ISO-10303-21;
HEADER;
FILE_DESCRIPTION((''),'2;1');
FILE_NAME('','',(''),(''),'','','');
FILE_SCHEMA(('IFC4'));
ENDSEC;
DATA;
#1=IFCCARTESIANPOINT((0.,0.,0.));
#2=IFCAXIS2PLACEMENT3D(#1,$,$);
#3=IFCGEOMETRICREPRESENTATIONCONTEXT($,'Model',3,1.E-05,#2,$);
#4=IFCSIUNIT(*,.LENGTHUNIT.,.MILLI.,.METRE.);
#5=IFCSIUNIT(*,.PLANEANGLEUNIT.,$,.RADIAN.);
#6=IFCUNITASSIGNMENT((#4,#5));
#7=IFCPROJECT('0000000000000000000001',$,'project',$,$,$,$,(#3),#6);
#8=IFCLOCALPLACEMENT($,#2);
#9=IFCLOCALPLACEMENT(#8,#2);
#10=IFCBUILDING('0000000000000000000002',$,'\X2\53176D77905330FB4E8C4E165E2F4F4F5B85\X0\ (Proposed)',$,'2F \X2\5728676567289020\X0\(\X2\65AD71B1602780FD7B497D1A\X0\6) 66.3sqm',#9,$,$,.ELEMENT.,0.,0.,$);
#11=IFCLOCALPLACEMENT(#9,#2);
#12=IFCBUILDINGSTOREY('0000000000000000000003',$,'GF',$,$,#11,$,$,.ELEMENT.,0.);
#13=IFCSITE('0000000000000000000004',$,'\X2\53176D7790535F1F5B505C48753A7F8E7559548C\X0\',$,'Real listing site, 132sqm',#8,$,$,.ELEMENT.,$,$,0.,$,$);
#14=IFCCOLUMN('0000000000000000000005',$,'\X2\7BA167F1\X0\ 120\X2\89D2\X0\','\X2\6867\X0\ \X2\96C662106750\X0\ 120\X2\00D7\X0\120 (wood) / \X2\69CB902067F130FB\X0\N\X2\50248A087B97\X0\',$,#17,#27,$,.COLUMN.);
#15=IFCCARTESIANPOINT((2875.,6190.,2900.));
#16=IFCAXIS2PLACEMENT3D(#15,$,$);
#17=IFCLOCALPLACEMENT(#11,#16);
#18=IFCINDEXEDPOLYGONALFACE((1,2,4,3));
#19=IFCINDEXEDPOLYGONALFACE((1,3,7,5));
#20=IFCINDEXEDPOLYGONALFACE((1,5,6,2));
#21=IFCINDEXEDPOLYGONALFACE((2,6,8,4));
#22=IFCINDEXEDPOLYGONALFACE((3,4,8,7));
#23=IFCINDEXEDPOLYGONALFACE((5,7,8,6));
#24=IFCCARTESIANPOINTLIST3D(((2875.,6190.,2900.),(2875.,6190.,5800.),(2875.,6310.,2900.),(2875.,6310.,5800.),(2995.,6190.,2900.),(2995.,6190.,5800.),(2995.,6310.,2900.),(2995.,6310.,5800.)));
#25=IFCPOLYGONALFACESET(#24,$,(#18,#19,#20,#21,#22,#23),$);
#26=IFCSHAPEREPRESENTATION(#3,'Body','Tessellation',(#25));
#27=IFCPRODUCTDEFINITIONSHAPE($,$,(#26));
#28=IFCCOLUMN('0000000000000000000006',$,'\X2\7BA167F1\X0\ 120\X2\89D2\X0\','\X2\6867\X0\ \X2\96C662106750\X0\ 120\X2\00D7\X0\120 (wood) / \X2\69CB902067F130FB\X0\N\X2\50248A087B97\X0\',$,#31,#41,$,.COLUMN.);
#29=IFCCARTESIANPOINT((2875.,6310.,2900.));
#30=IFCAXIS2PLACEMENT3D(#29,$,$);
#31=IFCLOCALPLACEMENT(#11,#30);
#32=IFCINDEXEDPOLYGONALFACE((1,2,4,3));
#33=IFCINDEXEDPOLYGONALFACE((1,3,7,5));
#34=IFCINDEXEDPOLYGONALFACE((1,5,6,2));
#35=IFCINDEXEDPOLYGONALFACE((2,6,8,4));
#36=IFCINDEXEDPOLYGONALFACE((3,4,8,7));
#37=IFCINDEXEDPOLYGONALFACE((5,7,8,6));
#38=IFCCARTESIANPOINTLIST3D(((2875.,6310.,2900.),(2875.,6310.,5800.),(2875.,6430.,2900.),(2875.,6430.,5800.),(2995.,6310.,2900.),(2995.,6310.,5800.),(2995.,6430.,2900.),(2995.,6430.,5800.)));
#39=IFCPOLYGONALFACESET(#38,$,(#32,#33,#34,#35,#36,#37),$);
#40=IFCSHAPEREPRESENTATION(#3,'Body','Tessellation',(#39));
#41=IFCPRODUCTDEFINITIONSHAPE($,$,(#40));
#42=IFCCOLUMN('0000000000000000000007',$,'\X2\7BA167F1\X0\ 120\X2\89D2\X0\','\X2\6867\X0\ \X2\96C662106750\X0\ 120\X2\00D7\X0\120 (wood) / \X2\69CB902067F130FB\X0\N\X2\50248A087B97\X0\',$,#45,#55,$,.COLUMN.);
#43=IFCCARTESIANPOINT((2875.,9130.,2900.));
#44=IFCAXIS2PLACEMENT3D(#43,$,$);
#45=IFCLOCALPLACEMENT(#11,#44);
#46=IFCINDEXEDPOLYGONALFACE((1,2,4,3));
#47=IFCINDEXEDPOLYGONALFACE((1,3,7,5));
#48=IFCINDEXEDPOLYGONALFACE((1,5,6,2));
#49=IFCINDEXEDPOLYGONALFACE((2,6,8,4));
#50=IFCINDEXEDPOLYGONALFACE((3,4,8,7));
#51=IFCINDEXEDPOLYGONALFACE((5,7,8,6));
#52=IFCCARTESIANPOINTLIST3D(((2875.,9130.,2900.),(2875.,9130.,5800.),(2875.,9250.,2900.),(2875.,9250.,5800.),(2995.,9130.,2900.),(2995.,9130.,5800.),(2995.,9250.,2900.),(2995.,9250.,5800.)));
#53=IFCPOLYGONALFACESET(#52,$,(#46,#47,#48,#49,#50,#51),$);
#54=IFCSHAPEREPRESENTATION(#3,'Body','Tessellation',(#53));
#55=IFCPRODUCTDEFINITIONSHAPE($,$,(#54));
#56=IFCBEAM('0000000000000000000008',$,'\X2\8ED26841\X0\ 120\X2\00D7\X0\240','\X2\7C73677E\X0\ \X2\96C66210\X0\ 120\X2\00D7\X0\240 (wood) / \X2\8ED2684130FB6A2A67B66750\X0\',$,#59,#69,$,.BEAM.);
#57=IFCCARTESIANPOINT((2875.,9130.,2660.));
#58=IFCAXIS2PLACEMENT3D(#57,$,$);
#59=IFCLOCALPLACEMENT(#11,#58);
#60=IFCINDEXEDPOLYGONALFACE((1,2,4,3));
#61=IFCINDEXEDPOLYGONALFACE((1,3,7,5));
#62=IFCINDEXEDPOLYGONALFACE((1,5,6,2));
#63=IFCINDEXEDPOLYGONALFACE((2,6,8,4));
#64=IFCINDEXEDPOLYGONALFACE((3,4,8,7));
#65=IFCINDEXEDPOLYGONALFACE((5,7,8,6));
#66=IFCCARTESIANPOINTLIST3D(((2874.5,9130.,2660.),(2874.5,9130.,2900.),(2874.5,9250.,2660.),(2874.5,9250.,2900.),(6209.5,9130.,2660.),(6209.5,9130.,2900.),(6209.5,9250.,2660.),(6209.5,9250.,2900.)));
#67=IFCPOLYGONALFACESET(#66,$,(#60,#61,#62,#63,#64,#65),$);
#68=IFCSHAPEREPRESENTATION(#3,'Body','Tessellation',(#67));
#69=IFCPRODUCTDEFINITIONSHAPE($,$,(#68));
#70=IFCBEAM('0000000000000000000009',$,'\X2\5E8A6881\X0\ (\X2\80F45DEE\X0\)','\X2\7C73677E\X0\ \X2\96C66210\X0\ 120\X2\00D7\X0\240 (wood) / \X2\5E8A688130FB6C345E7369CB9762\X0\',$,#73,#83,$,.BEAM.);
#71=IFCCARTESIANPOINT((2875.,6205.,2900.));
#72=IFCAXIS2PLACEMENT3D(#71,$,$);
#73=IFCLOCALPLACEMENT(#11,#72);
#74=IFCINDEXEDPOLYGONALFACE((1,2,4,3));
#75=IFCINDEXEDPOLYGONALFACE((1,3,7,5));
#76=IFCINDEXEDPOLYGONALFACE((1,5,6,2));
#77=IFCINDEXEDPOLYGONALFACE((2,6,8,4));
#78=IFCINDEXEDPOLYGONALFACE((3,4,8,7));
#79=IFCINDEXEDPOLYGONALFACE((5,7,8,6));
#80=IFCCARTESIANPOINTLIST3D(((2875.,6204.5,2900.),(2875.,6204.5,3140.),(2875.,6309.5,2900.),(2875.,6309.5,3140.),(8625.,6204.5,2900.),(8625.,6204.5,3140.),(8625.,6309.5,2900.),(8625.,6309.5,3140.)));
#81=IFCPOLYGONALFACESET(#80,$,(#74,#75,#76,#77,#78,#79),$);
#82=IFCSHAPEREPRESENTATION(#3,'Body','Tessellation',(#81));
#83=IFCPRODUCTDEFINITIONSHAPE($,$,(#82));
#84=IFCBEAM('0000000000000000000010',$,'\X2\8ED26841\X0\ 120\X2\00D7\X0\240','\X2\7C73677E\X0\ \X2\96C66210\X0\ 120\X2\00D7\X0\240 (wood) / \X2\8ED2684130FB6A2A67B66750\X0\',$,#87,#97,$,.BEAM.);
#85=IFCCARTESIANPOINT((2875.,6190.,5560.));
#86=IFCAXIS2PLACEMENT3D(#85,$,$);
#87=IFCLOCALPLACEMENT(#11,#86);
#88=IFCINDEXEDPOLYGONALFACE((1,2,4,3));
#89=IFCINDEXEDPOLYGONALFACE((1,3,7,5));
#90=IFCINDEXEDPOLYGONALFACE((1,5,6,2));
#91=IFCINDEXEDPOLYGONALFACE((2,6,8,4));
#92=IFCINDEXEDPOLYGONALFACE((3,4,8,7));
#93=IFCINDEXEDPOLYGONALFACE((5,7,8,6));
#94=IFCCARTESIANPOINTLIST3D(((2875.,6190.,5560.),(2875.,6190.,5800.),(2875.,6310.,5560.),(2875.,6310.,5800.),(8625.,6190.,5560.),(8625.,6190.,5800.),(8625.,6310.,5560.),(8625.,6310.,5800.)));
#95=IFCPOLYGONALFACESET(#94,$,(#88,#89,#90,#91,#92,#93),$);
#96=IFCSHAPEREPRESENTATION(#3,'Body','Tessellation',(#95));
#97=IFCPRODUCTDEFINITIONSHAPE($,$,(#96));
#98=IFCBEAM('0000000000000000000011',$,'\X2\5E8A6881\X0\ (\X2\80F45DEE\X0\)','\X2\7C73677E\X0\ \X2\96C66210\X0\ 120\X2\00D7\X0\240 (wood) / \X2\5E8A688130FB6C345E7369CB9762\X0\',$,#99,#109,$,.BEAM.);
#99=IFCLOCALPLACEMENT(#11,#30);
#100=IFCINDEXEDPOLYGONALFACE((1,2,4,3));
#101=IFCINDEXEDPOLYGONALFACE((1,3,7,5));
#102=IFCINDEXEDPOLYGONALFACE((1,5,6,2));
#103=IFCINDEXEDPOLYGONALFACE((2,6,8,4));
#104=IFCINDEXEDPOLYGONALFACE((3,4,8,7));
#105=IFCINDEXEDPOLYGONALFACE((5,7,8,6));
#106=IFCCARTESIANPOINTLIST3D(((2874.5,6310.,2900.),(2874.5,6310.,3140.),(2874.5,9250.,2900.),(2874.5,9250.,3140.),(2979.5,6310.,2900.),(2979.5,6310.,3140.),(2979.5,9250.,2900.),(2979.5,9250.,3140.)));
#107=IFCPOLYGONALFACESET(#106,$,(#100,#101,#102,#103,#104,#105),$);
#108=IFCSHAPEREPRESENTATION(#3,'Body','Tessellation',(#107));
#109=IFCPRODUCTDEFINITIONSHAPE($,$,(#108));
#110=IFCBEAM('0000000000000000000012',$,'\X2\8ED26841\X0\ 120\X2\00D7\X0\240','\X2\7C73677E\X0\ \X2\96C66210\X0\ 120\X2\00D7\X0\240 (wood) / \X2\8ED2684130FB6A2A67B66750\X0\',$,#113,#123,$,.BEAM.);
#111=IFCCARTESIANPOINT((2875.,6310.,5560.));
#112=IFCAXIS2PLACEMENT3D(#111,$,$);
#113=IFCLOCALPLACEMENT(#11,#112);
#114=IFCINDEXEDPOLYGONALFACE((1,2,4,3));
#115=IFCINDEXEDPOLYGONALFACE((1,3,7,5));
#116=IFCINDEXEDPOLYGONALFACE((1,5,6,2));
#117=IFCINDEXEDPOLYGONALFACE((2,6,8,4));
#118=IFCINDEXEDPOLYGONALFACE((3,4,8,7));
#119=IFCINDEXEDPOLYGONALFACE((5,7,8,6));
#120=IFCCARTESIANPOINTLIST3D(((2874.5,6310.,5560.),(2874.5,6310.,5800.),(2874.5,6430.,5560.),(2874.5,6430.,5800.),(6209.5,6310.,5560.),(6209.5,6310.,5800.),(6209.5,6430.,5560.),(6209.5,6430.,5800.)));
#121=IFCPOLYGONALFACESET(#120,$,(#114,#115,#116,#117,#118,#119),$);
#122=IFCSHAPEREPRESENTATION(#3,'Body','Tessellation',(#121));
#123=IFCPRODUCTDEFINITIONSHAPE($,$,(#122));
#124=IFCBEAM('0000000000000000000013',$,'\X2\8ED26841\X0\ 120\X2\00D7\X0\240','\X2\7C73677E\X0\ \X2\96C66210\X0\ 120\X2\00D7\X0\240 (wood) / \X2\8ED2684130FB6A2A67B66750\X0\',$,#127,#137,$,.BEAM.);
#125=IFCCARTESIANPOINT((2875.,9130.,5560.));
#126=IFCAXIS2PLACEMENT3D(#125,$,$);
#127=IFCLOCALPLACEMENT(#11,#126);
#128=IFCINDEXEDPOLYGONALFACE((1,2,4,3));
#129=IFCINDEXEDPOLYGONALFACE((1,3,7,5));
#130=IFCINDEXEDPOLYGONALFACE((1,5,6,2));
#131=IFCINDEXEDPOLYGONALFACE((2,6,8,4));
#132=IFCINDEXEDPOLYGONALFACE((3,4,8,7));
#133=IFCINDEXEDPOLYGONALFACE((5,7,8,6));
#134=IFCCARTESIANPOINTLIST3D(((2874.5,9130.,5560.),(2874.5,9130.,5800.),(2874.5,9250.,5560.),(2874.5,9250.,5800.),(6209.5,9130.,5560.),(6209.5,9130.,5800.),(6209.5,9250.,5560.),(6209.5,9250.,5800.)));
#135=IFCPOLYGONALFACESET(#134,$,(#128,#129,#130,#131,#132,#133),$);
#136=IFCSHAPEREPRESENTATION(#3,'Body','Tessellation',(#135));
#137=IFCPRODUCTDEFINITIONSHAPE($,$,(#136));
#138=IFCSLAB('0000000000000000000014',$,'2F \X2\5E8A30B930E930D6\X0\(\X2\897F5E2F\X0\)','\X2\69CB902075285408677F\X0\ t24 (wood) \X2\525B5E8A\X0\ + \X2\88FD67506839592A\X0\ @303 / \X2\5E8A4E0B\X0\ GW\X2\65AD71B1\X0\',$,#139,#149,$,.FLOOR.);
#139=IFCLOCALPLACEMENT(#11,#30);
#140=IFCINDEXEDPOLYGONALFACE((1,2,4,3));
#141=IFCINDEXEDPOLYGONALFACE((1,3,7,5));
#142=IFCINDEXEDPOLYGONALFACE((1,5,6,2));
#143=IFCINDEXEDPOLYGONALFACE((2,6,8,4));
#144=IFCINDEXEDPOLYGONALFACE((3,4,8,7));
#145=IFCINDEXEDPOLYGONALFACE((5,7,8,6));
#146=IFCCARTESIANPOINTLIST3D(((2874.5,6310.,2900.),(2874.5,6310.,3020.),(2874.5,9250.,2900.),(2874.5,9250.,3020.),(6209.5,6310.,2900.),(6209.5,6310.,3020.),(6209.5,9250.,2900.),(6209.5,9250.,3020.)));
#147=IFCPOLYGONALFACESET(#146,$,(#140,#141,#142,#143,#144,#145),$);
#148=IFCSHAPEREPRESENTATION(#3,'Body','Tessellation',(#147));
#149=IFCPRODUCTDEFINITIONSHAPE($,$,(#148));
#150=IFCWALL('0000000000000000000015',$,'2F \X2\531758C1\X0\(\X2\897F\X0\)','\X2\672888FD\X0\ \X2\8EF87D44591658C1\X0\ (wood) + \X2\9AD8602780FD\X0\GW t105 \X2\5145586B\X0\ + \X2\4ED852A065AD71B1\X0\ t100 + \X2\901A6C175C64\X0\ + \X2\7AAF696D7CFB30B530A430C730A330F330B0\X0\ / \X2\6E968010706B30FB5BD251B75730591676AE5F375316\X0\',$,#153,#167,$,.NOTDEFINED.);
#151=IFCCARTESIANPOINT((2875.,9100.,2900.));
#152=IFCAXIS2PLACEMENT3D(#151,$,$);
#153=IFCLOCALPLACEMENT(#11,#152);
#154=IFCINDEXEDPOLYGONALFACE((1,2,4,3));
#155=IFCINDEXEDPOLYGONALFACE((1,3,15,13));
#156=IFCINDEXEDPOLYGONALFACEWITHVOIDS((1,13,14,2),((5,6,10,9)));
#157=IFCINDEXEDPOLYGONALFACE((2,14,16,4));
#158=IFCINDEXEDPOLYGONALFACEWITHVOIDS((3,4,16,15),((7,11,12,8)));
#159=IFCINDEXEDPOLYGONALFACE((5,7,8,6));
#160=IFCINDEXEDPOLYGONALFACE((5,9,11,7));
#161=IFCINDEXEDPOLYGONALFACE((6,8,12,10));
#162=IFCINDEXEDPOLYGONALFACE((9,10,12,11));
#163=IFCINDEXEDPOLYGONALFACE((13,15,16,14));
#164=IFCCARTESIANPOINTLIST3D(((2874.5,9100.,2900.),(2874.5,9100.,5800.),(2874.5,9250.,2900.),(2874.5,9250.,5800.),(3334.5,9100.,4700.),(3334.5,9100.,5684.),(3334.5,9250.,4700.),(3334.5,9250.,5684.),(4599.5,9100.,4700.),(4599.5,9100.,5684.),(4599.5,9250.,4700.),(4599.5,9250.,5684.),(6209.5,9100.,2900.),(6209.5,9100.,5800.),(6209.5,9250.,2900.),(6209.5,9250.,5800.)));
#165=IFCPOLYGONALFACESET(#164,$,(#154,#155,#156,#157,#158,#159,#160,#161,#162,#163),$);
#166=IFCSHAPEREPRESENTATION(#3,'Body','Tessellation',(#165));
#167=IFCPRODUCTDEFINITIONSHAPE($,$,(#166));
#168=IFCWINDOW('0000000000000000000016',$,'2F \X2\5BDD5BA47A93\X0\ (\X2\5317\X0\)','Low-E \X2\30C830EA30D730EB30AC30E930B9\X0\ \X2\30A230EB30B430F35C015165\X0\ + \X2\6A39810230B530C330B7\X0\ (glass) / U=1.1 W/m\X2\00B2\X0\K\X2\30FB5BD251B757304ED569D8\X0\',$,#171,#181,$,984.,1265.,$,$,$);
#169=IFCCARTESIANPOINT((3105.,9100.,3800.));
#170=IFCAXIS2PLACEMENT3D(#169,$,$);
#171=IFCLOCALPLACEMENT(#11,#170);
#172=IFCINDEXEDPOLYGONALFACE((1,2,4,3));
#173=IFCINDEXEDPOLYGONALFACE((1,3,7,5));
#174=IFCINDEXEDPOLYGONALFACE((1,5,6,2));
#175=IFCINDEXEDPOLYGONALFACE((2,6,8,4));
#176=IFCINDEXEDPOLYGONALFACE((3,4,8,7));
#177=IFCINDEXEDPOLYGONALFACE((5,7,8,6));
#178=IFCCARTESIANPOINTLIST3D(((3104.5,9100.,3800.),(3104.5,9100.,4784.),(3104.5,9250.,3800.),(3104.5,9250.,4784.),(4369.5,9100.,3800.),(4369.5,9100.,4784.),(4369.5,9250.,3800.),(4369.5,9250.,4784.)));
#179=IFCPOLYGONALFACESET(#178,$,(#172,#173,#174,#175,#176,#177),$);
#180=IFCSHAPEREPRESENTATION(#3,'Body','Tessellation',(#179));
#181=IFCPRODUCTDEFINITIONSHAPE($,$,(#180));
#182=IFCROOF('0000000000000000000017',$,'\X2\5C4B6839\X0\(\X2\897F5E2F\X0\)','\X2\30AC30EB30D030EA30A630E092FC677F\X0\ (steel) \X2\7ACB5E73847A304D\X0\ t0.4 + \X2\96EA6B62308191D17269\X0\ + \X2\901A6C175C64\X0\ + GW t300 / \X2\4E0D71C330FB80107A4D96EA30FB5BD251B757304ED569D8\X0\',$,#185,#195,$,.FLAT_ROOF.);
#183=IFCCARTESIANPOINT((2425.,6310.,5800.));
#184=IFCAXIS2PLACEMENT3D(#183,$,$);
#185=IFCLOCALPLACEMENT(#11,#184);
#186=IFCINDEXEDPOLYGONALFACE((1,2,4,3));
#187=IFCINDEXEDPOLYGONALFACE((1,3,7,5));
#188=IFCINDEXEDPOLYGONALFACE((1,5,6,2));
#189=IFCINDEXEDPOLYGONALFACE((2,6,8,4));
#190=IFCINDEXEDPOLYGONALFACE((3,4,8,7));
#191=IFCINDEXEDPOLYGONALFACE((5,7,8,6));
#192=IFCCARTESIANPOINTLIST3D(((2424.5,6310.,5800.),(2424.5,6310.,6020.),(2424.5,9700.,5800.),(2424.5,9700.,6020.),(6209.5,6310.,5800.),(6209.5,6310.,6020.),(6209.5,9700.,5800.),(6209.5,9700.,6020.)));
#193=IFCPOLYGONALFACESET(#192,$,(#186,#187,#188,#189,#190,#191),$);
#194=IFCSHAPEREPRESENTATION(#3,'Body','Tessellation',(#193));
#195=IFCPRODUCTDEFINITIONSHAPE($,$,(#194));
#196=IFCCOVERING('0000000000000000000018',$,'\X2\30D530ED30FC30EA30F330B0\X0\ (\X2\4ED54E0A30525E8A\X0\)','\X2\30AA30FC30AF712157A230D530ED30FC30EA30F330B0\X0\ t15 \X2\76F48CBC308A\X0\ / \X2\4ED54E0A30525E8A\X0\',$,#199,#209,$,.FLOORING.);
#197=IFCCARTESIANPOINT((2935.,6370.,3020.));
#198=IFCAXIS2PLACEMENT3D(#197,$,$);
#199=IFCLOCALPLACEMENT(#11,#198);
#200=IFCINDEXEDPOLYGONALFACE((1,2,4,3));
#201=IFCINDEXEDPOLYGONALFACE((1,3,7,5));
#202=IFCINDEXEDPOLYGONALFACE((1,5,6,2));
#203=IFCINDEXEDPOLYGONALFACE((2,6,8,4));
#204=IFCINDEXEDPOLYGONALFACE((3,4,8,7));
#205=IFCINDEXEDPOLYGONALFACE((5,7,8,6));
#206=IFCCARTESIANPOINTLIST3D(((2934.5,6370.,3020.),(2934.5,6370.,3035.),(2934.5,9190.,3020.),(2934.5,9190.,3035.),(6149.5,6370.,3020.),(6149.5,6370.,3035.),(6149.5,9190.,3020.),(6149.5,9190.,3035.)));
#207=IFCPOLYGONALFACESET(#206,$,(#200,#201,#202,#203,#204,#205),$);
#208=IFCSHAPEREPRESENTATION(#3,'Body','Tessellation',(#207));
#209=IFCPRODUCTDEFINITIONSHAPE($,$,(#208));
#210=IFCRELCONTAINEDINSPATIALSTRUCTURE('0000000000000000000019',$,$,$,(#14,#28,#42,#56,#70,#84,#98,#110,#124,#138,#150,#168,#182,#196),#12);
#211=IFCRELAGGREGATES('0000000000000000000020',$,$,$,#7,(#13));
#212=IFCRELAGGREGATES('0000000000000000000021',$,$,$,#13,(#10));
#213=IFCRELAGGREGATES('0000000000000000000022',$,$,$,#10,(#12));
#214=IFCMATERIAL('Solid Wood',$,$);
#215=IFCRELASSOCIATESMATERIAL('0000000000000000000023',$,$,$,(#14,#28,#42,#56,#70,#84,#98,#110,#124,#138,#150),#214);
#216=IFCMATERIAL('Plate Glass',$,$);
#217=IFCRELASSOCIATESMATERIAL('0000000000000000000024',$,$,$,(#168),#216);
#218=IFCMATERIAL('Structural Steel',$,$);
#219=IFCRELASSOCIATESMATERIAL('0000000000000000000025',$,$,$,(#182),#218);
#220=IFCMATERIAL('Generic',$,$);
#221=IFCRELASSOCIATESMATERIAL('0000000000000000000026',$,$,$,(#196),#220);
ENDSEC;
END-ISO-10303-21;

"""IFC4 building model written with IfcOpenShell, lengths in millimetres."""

from ifc_helpers import new_model, si_unit, frame, frame_2d, origin, place, context, project, spatial, rectangle, extrude, material, element, fill, save


model = new_model("IFC4")

# Units and contexts
model_context = context("Model", 3, precision=1e-05, world=origin())
ifc_project = project(units=[si_unit("LENGTHUNIT", "METRE", prefix="MILLI"), si_unit("PLANEANGLEUNIT", "RADIAN")], contexts=[model_context])

# Site, building, storey
site_placement = place(None, origin())
site = spatial("IfcSite", under=ifc_project, at=site_placement, Name="北海道弟子屈町美留和", ObjectType="Real listing site, 132sqm", CompositionType="ELEMENT", RefElevation=0.0)
building_placement = place(site_placement, origin())
building = spatial("IfcBuilding", under=site, at=building_placement, Name="北海道・二世帯住宅 (Proposed)", ObjectType="2F 在来木造(断熱性能等級6) 66.3sqm", CompositionType="ELEMENT", ElevationOfRefHeight=0.0, ElevationOfTerrain=0.0)
storey_placement = place(building_placement, origin())
storey = spatial("IfcBuildingStorey", under=building, at=storey_placement, Name="GF", CompositionType="ELEMENT", Elevation=0.0)

# Columns
ifc_material_1 = material(Name="Solid Wood")
column_1_placement = place(storey_placement, frame((2875.0, 6190.0, 2900.0)))
element("IfcColumn", 1, at=column_1_placement, inside=storey, material=ifc_material_1, Name="管柱 120角", Description="桧 集成材 120×120 (wood) / 構造柱・N値計算", PredefinedType="COLUMN", context=model_context, shape_type="SweptSolid", body=[
    extrude(rectangle(XDim=120.0, YDim=120.0, at=frame_2d((60.0, 60.0))), frame((2875.0, 6190.0, 2900.0)), (0.0, 0.0, 1.0), 2900.0),
])
column_2_placement = place(storey_placement, frame((2875.0, 6310.0, 2900.0)))
element("IfcColumn", 2, at=column_2_placement, inside=storey, material=ifc_material_1, Name="管柱 120角", Description="桧 集成材 120×120 (wood) / 構造柱・N値計算", PredefinedType="COLUMN", context=model_context, shape_type="SweptSolid", body=[
    extrude(rectangle(XDim=120.0, YDim=120.0, at=frame_2d((60.0, 60.0))), frame((2875.0, 6310.0, 2900.0)), (0.0, 0.0, 1.0), 2900.0),
])
column_3_placement = place(storey_placement, frame((2875.0, 9130.0, 2900.0)))
element("IfcColumn", 3, at=column_3_placement, inside=storey, material=ifc_material_1, Name="管柱 120角", Description="桧 集成材 120×120 (wood) / 構造柱・N値計算", PredefinedType="COLUMN", context=model_context, shape_type="SweptSolid", body=[
    extrude(rectangle(XDim=120.0, YDim=120.0, at=frame_2d((60.0, 60.0))), frame((2875.0, 9130.0, 2900.0)), (0.0, 0.0, 1.0), 2900.0),
])

# Beams
beam_1_placement = place(storey_placement, frame((2875.0, 9130.0, 2660.0)))
element("IfcBeam", 4, at=beam_1_placement, inside=storey, material=ifc_material_1, Name="軒桁 120×240", Description="米松 集成 120×240 (wood) / 軒桁・横架材", PredefinedType="BEAM", context=model_context, shape_type="SweptSolid", body=[
    extrude(rectangle(XDim=3335.0, YDim=120.0, at=frame_2d((1667.0, 60.0))), frame((2875.0, 9130.0, 2660.0)), (0.0, 0.0, 1.0), 240.0),
])
beam_2_placement = place(storey_placement, frame((2875.0, 6205.0, 2900.0)))
element("IfcBeam", 5, at=beam_2_placement, inside=storey, material=ifc_material_1, Name="床梁 (胴差)", Description="米松 集成 120×240 (wood) / 床梁・水平構面", PredefinedType="BEAM", context=model_context, shape_type="SweptSolid", body=[
    extrude(rectangle(XDim=5750.0, YDim=105.0, at=frame_2d((2875.0, 52.0))), frame((2875.0, 6205.0, 2900.0)), (0.0, 0.0, 1.0), 240.0),
])
beam_3_placement = place(storey_placement, frame((2875.0, 6190.0, 5560.0)))
element("IfcBeam", 6, at=beam_3_placement, inside=storey, material=ifc_material_1, Name="軒桁 120×240", Description="米松 集成 120×240 (wood) / 軒桁・横架材", PredefinedType="BEAM", context=model_context, shape_type="SweptSolid", body=[
    extrude(rectangle(XDim=5750.0, YDim=120.0, at=frame_2d((2875.0, 60.0))), frame((2875.0, 6190.0, 5560.0)), (0.0, 0.0, 1.0), 240.0),
])
beam_4_placement = place(storey_placement, frame((2875.0, 6310.0, 2900.0)))
element("IfcBeam", 7, at=beam_4_placement, inside=storey, material=ifc_material_1, Name="床梁 (胴差)", Description="米松 集成 120×240 (wood) / 床梁・水平構面", PredefinedType="BEAM", context=model_context, shape_type="SweptSolid", body=[
    extrude(rectangle(XDim=105.0, YDim=2940.0, at=frame_2d((52.0, 1470.0))), frame((2875.0, 6310.0, 2900.0)), (0.0, 0.0, 1.0), 240.0),
])
beam_5_placement = place(storey_placement, frame((2875.0, 6310.0, 5560.0)))
element("IfcBeam", 8, at=beam_5_placement, inside=storey, material=ifc_material_1, Name="軒桁 120×240", Description="米松 集成 120×240 (wood) / 軒桁・横架材", PredefinedType="BEAM", context=model_context, shape_type="SweptSolid", body=[
    extrude(rectangle(XDim=3335.0, YDim=120.0, at=frame_2d((1667.0, 60.0))), frame((2875.0, 6310.0, 5560.0)), (0.0, 0.0, 1.0), 240.0),
])
beam_6_placement = place(storey_placement, frame((2875.0, 9130.0, 5560.0)))
element("IfcBeam", 9, at=beam_6_placement, inside=storey, material=ifc_material_1, Name="軒桁 120×240", Description="米松 集成 120×240 (wood) / 軒桁・横架材", PredefinedType="BEAM", context=model_context, shape_type="SweptSolid", body=[
    extrude(rectangle(XDim=3335.0, YDim=120.0, at=frame_2d((1667.0, 60.0))), frame((2875.0, 9130.0, 5560.0)), (0.0, 0.0, 1.0), 240.0),
])

# Slab
slab_placement = place(storey_placement, frame((2875.0, 6310.0, 2900.0)))
element("IfcSlab", 10, at=slab_placement, inside=storey, material=ifc_material_1, Name="2F 床スラブ(西帯)", Description="構造用合板 t24 (wood) 剛床 + 製材根太 @303 / 床下 GW断熱", PredefinedType="FLOOR", context=model_context, shape_type="SweptSolid", body=[
    extrude(rectangle(XDim=3335.0, YDim=2940.0, at=frame_2d((1667.0, 1470.0))), frame((2875.0, 6310.0, 2900.0)), (0.0, 0.0, 1.0), 120.0),
])

# Wall, opening, window
wall_1_placement = place(storey_placement, frame((2875.0, 9100.0, 2900.0)))
wall_1 = element("IfcWall", 11, at=wall_1_placement, inside=storey, material=ifc_material_1, Name="2F 北壁(西)", Description="木製 軸組外壁 (wood) + 高性能GW t105 充填 + 付加断熱 t100 + 通気層 + 窯業系サイディング / 準耐火・寒冷地外皮強化", PredefinedType="NOTDEFINED", context=model_context, shape_type="SweptSolid", body=[
    extrude(rectangle(XDim=3335.0, YDim=150.0, at=frame_2d((1667.0, 75.0))), frame((2875.0, 9100.0, 2900.0)), (0.0, 0.0, 1.0), 2900.0),
])
opening_placement = place(storey_placement, frame((3105.0, 9100.0, 3800.0)))
opening = element("IfcOpeningElement", 12, at=opening_placement, cuts=wall_1, PredefinedType="NOTDEFINED", context=model_context, shape_type="SweptSolid", body=[
    extrude(rectangle(XDim=1265.0, YDim=150.0, at=frame_2d((632.0, 75.0))), frame((3105.0, 9100.0, 3800.0)), (0.0, 0.0, 1.0), 984.0),
])
ifc_material_2 = material(Name="Plate Glass")
window_placement = place(storey_placement, frame((3105.0, 9100.0, 3800.0)))
window = element("IfcWindow", 13, at=window_placement, inside=storey, material=ifc_material_2, Name="2F 寝室窓 (北)", Description="Low-E トリプルガラス アルゴン封入 + 樹脂サッシ (glass) / U=1.1 W/m²K・寒冷地仕様", OverallHeight=984.0, OverallWidth=1265.0, context=model_context, shape_type="SweptSolid", body=[
    extrude(rectangle(XDim=1265.0, YDim=150.0, at=frame_2d((632.0, 75.0))), frame((3105.0, 9100.0, 3800.0)), (0.0, 0.0, 1.0), 984.0),
])
fill(opening, window)

# Roof
ifc_material_3 = material(Name="Structural Steel")
for number, where, name in (
    (14, (2425.0, 6310.0, 5800.0), "屋根(西帯)"),
):
    element("IfcRoof", number, at=place(storey_placement, frame(where)), inside=storey, material=ifc_material_3, Name=name, Description="ガルバリウム鋼板 (steel) 立平葺き t0.4 + 雪止め金物 + 通気層 + GW t300 / 不燃・耐積雪・寒冷地仕様", PredefinedType="FLAT_ROOF", context=model_context, shape_type="SweptSolid", body=[
        extrude(rectangle(XDim=3785.0, YDim=3390.0, at=frame_2d((1892.0, 1695.0))), frame((2425.0, 6310.0, 5800.0)), (0.0, 0.0, 1.0), 220.0),
    ])

# Covering
ifc_material_4 = material(Name="Generic")
covering_placement = place(storey_placement, frame((2935.0, 6370.0, 3020.0)))
element("IfcCovering", 15, at=covering_placement, inside=storey, material=ifc_material_4, Name="フローリング (仕上げ床)", Description="オーク無垢フローリング t15 直貼り / 仕上げ床", PredefinedType="FLOORING", context=model_context, shape_type="SweptSolid", body=[
    extrude(rectangle(XDim=3215.0, YDim=2820.0, at=frame_2d((1607.0, 1410.0))), frame((2935.0, 6370.0, 3020.0)), (0.0, 0.0, 1.0), 15.0),
])

save(model, "model.ifc")
